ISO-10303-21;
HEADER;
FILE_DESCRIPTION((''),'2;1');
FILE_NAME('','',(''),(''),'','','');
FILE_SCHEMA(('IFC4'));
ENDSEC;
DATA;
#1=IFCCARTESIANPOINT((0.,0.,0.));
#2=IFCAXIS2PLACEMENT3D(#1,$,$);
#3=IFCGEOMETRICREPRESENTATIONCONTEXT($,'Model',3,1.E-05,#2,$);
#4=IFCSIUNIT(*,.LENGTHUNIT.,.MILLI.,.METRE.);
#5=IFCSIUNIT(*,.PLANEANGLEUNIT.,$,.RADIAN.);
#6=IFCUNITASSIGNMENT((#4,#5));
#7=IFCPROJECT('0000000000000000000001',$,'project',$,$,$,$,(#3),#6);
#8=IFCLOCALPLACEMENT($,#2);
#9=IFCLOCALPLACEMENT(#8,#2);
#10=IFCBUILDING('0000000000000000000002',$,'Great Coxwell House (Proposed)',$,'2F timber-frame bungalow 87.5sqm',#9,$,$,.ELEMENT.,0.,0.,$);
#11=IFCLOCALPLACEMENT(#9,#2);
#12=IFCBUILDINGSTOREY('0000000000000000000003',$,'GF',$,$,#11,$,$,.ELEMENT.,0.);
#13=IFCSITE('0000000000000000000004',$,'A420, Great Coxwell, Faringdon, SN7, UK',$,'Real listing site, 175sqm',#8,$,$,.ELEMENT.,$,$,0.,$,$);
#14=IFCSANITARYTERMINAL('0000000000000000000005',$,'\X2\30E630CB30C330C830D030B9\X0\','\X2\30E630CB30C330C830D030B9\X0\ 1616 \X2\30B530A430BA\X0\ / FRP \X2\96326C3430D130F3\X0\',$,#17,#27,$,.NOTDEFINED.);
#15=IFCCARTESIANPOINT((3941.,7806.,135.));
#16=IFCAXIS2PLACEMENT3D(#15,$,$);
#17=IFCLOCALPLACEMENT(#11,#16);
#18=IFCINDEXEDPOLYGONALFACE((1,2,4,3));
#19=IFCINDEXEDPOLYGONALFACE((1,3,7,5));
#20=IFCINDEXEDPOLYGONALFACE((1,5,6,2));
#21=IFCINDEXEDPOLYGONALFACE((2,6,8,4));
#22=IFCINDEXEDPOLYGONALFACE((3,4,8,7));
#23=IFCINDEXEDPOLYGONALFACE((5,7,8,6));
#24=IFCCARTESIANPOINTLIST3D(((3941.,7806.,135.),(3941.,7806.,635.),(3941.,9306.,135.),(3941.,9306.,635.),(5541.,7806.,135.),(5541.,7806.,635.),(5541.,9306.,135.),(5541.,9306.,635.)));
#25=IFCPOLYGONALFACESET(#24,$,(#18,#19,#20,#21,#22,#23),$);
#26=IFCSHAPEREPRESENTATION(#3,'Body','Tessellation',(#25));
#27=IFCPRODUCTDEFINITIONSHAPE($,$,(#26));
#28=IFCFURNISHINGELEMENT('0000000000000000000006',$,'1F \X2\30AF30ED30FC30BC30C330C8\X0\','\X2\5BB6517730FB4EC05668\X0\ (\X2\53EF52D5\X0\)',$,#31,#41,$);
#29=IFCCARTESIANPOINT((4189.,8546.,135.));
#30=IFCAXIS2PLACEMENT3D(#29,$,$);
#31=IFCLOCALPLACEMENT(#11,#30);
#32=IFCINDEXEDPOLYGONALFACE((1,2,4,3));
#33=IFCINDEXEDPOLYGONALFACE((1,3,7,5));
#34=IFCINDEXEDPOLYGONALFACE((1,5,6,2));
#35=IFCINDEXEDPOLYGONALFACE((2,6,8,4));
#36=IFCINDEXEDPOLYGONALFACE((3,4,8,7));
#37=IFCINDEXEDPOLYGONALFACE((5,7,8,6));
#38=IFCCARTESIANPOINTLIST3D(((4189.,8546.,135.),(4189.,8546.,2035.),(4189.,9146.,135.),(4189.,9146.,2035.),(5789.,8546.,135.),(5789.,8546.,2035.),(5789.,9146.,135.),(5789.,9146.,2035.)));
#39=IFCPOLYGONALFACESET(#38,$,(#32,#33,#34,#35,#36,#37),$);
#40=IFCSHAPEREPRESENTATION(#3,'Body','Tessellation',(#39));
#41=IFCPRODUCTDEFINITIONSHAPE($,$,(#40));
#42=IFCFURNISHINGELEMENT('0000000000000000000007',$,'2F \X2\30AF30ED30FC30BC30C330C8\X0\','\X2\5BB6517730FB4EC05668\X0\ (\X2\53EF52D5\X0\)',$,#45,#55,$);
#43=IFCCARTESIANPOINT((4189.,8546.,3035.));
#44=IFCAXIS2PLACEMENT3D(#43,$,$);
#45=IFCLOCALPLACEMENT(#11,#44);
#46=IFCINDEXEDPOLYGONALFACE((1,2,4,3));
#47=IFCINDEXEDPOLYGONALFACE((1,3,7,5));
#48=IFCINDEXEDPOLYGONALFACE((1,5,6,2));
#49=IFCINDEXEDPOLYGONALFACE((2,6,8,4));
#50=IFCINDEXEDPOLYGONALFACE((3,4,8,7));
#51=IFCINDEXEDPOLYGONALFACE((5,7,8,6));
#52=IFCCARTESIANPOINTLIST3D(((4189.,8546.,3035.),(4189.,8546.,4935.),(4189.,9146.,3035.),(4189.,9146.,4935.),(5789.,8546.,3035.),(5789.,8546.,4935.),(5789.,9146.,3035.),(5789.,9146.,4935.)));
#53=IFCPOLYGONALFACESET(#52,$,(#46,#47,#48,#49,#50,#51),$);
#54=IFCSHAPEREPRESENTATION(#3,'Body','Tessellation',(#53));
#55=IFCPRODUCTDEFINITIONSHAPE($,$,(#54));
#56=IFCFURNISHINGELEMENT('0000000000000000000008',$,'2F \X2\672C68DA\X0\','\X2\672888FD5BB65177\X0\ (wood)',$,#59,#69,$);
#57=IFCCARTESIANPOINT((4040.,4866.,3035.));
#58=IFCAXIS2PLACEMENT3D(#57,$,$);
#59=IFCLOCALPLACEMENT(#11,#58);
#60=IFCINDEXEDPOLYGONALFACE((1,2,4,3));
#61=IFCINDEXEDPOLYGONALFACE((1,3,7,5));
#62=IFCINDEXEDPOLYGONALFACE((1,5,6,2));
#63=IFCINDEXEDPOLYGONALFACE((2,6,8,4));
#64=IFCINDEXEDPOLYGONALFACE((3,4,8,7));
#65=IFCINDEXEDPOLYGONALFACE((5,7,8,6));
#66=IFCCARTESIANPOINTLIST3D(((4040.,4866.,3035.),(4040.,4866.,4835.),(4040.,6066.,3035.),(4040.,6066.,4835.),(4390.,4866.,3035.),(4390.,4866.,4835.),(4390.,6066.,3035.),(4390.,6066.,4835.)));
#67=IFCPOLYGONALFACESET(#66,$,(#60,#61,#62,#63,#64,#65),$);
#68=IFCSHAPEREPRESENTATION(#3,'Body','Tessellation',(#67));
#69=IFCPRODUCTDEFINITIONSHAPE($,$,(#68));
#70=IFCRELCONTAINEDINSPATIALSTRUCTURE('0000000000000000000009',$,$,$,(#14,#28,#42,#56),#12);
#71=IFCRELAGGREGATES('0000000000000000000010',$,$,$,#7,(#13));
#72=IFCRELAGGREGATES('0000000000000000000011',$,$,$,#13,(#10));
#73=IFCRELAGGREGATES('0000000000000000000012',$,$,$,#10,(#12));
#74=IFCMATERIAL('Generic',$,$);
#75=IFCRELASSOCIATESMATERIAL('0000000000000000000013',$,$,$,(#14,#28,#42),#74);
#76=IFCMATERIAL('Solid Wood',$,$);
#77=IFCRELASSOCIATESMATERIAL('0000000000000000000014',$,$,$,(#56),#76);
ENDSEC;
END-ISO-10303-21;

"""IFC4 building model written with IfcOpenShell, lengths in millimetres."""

from ifc_helpers import new_model, si_unit, frame, frame_2d, origin, place, context, project, spatial, rectangle, extrude, material, element, save


model = new_model("IFC4")

# Units and contexts
model_context = context("Model", 3, precision=1e-05, world=origin())
ifc_project = project(units=[si_unit("LENGTHUNIT", "METRE", prefix="MILLI"), si_unit("PLANEANGLEUNIT", "RADIAN")], contexts=[model_context])

# Site, building, storey
site_placement = place(None, origin())
site = spatial("IfcSite", under=ifc_project, at=site_placement, Name="A420, Great Coxwell, Faringdon, SN7, UK", ObjectType="Real listing site, 175sqm", CompositionType="ELEMENT", RefElevation=0.0)
building_placement = place(site_placement, origin())
building = spatial("IfcBuilding", under=site, at=building_placement, Name="Great Coxwell House (Proposed)", ObjectType="2F timber-frame bungalow 87.5sqm", CompositionType="ELEMENT", ElevationOfRefHeight=0.0, ElevationOfTerrain=0.0)
storey_placement = place(building_placement, origin())
storey = spatial("IfcBuildingStorey", under=building, at=storey_placement, Name="GF", CompositionType="ELEMENT", Elevation=0.0)

# Shared definitions
ifc_material_1 = material(Name="Solid Wood")

# Shared definitions
ifc_material_2 = material(Name="Generic")

# Sanitary terminal
sanitary_terminal_placement = place(storey_placement, frame((3941.0, 7806.0, 135.0)))
element("IfcSanitaryTerminal", 1, at=sanitary_terminal_placement, inside=storey, material=ifc_material_2, Name="ユニットバス", Description="ユニットバス 1616 サイズ / FRP 防水パン", PredefinedType="NOTDEFINED", context=model_context, shape_type="SweptSolid", body=[
    extrude(rectangle(XDim=1600.0, YDim=1500.0, at=frame_2d((800.0, 750.0))), frame((3941.0, 7806.0, 135.0)), (0.0, 0.0, 1.0), 500.0),
])

# Furnishing elements
furnishing_1_placement = place(storey_placement, frame((4189.0, 8546.0, 135.0)))
element("IfcFurnishingElement", 2, at=furnishing_1_placement, inside=storey, material=ifc_material_2, Name="1F クローゼット", Description="家具・什器 (可動)", context=model_context, shape_type="SweptSolid", body=[
    extrude(rectangle(XDim=1600.0, YDim=600.0, at=frame_2d((800.0, 300.0))), frame((4189.0, 8546.0, 135.0)), (0.0, 0.0, 1.0), 1900.0),
])
furnishing_2_placement = place(storey_placement, frame((4189.0, 8546.0, 3035.0)))
element("IfcFurnishingElement", 3, at=furnishing_2_placement, inside=storey, material=ifc_material_2, Name="2F クローゼット", Description="家具・什器 (可動)", context=model_context, shape_type="SweptSolid", body=[
    extrude(rectangle(XDim=1600.0, YDim=600.0, at=frame_2d((800.0, 300.0))), frame((4189.0, 8546.0, 3035.0)), (0.0, 0.0, 1.0), 1900.0),
])
furnishing_3_placement = place(storey_placement, frame((4040.0, 4866.0, 3035.0)))
element("IfcFurnishingElement", 4, at=furnishing_3_placement, inside=storey, material=ifc_material_1, Name="2F 本棚", Description="木製家具 (wood)", context=model_context, shape_type="SweptSolid", body=[
    extrude(rectangle(XDim=350.0, YDim=1200.0, at=frame_2d((175.0, 600.0))), frame((4040.0, 4866.0, 3035.0)), (0.0, 0.0, 1.0), 1800.0),
])

save(model, "model.ifc")
